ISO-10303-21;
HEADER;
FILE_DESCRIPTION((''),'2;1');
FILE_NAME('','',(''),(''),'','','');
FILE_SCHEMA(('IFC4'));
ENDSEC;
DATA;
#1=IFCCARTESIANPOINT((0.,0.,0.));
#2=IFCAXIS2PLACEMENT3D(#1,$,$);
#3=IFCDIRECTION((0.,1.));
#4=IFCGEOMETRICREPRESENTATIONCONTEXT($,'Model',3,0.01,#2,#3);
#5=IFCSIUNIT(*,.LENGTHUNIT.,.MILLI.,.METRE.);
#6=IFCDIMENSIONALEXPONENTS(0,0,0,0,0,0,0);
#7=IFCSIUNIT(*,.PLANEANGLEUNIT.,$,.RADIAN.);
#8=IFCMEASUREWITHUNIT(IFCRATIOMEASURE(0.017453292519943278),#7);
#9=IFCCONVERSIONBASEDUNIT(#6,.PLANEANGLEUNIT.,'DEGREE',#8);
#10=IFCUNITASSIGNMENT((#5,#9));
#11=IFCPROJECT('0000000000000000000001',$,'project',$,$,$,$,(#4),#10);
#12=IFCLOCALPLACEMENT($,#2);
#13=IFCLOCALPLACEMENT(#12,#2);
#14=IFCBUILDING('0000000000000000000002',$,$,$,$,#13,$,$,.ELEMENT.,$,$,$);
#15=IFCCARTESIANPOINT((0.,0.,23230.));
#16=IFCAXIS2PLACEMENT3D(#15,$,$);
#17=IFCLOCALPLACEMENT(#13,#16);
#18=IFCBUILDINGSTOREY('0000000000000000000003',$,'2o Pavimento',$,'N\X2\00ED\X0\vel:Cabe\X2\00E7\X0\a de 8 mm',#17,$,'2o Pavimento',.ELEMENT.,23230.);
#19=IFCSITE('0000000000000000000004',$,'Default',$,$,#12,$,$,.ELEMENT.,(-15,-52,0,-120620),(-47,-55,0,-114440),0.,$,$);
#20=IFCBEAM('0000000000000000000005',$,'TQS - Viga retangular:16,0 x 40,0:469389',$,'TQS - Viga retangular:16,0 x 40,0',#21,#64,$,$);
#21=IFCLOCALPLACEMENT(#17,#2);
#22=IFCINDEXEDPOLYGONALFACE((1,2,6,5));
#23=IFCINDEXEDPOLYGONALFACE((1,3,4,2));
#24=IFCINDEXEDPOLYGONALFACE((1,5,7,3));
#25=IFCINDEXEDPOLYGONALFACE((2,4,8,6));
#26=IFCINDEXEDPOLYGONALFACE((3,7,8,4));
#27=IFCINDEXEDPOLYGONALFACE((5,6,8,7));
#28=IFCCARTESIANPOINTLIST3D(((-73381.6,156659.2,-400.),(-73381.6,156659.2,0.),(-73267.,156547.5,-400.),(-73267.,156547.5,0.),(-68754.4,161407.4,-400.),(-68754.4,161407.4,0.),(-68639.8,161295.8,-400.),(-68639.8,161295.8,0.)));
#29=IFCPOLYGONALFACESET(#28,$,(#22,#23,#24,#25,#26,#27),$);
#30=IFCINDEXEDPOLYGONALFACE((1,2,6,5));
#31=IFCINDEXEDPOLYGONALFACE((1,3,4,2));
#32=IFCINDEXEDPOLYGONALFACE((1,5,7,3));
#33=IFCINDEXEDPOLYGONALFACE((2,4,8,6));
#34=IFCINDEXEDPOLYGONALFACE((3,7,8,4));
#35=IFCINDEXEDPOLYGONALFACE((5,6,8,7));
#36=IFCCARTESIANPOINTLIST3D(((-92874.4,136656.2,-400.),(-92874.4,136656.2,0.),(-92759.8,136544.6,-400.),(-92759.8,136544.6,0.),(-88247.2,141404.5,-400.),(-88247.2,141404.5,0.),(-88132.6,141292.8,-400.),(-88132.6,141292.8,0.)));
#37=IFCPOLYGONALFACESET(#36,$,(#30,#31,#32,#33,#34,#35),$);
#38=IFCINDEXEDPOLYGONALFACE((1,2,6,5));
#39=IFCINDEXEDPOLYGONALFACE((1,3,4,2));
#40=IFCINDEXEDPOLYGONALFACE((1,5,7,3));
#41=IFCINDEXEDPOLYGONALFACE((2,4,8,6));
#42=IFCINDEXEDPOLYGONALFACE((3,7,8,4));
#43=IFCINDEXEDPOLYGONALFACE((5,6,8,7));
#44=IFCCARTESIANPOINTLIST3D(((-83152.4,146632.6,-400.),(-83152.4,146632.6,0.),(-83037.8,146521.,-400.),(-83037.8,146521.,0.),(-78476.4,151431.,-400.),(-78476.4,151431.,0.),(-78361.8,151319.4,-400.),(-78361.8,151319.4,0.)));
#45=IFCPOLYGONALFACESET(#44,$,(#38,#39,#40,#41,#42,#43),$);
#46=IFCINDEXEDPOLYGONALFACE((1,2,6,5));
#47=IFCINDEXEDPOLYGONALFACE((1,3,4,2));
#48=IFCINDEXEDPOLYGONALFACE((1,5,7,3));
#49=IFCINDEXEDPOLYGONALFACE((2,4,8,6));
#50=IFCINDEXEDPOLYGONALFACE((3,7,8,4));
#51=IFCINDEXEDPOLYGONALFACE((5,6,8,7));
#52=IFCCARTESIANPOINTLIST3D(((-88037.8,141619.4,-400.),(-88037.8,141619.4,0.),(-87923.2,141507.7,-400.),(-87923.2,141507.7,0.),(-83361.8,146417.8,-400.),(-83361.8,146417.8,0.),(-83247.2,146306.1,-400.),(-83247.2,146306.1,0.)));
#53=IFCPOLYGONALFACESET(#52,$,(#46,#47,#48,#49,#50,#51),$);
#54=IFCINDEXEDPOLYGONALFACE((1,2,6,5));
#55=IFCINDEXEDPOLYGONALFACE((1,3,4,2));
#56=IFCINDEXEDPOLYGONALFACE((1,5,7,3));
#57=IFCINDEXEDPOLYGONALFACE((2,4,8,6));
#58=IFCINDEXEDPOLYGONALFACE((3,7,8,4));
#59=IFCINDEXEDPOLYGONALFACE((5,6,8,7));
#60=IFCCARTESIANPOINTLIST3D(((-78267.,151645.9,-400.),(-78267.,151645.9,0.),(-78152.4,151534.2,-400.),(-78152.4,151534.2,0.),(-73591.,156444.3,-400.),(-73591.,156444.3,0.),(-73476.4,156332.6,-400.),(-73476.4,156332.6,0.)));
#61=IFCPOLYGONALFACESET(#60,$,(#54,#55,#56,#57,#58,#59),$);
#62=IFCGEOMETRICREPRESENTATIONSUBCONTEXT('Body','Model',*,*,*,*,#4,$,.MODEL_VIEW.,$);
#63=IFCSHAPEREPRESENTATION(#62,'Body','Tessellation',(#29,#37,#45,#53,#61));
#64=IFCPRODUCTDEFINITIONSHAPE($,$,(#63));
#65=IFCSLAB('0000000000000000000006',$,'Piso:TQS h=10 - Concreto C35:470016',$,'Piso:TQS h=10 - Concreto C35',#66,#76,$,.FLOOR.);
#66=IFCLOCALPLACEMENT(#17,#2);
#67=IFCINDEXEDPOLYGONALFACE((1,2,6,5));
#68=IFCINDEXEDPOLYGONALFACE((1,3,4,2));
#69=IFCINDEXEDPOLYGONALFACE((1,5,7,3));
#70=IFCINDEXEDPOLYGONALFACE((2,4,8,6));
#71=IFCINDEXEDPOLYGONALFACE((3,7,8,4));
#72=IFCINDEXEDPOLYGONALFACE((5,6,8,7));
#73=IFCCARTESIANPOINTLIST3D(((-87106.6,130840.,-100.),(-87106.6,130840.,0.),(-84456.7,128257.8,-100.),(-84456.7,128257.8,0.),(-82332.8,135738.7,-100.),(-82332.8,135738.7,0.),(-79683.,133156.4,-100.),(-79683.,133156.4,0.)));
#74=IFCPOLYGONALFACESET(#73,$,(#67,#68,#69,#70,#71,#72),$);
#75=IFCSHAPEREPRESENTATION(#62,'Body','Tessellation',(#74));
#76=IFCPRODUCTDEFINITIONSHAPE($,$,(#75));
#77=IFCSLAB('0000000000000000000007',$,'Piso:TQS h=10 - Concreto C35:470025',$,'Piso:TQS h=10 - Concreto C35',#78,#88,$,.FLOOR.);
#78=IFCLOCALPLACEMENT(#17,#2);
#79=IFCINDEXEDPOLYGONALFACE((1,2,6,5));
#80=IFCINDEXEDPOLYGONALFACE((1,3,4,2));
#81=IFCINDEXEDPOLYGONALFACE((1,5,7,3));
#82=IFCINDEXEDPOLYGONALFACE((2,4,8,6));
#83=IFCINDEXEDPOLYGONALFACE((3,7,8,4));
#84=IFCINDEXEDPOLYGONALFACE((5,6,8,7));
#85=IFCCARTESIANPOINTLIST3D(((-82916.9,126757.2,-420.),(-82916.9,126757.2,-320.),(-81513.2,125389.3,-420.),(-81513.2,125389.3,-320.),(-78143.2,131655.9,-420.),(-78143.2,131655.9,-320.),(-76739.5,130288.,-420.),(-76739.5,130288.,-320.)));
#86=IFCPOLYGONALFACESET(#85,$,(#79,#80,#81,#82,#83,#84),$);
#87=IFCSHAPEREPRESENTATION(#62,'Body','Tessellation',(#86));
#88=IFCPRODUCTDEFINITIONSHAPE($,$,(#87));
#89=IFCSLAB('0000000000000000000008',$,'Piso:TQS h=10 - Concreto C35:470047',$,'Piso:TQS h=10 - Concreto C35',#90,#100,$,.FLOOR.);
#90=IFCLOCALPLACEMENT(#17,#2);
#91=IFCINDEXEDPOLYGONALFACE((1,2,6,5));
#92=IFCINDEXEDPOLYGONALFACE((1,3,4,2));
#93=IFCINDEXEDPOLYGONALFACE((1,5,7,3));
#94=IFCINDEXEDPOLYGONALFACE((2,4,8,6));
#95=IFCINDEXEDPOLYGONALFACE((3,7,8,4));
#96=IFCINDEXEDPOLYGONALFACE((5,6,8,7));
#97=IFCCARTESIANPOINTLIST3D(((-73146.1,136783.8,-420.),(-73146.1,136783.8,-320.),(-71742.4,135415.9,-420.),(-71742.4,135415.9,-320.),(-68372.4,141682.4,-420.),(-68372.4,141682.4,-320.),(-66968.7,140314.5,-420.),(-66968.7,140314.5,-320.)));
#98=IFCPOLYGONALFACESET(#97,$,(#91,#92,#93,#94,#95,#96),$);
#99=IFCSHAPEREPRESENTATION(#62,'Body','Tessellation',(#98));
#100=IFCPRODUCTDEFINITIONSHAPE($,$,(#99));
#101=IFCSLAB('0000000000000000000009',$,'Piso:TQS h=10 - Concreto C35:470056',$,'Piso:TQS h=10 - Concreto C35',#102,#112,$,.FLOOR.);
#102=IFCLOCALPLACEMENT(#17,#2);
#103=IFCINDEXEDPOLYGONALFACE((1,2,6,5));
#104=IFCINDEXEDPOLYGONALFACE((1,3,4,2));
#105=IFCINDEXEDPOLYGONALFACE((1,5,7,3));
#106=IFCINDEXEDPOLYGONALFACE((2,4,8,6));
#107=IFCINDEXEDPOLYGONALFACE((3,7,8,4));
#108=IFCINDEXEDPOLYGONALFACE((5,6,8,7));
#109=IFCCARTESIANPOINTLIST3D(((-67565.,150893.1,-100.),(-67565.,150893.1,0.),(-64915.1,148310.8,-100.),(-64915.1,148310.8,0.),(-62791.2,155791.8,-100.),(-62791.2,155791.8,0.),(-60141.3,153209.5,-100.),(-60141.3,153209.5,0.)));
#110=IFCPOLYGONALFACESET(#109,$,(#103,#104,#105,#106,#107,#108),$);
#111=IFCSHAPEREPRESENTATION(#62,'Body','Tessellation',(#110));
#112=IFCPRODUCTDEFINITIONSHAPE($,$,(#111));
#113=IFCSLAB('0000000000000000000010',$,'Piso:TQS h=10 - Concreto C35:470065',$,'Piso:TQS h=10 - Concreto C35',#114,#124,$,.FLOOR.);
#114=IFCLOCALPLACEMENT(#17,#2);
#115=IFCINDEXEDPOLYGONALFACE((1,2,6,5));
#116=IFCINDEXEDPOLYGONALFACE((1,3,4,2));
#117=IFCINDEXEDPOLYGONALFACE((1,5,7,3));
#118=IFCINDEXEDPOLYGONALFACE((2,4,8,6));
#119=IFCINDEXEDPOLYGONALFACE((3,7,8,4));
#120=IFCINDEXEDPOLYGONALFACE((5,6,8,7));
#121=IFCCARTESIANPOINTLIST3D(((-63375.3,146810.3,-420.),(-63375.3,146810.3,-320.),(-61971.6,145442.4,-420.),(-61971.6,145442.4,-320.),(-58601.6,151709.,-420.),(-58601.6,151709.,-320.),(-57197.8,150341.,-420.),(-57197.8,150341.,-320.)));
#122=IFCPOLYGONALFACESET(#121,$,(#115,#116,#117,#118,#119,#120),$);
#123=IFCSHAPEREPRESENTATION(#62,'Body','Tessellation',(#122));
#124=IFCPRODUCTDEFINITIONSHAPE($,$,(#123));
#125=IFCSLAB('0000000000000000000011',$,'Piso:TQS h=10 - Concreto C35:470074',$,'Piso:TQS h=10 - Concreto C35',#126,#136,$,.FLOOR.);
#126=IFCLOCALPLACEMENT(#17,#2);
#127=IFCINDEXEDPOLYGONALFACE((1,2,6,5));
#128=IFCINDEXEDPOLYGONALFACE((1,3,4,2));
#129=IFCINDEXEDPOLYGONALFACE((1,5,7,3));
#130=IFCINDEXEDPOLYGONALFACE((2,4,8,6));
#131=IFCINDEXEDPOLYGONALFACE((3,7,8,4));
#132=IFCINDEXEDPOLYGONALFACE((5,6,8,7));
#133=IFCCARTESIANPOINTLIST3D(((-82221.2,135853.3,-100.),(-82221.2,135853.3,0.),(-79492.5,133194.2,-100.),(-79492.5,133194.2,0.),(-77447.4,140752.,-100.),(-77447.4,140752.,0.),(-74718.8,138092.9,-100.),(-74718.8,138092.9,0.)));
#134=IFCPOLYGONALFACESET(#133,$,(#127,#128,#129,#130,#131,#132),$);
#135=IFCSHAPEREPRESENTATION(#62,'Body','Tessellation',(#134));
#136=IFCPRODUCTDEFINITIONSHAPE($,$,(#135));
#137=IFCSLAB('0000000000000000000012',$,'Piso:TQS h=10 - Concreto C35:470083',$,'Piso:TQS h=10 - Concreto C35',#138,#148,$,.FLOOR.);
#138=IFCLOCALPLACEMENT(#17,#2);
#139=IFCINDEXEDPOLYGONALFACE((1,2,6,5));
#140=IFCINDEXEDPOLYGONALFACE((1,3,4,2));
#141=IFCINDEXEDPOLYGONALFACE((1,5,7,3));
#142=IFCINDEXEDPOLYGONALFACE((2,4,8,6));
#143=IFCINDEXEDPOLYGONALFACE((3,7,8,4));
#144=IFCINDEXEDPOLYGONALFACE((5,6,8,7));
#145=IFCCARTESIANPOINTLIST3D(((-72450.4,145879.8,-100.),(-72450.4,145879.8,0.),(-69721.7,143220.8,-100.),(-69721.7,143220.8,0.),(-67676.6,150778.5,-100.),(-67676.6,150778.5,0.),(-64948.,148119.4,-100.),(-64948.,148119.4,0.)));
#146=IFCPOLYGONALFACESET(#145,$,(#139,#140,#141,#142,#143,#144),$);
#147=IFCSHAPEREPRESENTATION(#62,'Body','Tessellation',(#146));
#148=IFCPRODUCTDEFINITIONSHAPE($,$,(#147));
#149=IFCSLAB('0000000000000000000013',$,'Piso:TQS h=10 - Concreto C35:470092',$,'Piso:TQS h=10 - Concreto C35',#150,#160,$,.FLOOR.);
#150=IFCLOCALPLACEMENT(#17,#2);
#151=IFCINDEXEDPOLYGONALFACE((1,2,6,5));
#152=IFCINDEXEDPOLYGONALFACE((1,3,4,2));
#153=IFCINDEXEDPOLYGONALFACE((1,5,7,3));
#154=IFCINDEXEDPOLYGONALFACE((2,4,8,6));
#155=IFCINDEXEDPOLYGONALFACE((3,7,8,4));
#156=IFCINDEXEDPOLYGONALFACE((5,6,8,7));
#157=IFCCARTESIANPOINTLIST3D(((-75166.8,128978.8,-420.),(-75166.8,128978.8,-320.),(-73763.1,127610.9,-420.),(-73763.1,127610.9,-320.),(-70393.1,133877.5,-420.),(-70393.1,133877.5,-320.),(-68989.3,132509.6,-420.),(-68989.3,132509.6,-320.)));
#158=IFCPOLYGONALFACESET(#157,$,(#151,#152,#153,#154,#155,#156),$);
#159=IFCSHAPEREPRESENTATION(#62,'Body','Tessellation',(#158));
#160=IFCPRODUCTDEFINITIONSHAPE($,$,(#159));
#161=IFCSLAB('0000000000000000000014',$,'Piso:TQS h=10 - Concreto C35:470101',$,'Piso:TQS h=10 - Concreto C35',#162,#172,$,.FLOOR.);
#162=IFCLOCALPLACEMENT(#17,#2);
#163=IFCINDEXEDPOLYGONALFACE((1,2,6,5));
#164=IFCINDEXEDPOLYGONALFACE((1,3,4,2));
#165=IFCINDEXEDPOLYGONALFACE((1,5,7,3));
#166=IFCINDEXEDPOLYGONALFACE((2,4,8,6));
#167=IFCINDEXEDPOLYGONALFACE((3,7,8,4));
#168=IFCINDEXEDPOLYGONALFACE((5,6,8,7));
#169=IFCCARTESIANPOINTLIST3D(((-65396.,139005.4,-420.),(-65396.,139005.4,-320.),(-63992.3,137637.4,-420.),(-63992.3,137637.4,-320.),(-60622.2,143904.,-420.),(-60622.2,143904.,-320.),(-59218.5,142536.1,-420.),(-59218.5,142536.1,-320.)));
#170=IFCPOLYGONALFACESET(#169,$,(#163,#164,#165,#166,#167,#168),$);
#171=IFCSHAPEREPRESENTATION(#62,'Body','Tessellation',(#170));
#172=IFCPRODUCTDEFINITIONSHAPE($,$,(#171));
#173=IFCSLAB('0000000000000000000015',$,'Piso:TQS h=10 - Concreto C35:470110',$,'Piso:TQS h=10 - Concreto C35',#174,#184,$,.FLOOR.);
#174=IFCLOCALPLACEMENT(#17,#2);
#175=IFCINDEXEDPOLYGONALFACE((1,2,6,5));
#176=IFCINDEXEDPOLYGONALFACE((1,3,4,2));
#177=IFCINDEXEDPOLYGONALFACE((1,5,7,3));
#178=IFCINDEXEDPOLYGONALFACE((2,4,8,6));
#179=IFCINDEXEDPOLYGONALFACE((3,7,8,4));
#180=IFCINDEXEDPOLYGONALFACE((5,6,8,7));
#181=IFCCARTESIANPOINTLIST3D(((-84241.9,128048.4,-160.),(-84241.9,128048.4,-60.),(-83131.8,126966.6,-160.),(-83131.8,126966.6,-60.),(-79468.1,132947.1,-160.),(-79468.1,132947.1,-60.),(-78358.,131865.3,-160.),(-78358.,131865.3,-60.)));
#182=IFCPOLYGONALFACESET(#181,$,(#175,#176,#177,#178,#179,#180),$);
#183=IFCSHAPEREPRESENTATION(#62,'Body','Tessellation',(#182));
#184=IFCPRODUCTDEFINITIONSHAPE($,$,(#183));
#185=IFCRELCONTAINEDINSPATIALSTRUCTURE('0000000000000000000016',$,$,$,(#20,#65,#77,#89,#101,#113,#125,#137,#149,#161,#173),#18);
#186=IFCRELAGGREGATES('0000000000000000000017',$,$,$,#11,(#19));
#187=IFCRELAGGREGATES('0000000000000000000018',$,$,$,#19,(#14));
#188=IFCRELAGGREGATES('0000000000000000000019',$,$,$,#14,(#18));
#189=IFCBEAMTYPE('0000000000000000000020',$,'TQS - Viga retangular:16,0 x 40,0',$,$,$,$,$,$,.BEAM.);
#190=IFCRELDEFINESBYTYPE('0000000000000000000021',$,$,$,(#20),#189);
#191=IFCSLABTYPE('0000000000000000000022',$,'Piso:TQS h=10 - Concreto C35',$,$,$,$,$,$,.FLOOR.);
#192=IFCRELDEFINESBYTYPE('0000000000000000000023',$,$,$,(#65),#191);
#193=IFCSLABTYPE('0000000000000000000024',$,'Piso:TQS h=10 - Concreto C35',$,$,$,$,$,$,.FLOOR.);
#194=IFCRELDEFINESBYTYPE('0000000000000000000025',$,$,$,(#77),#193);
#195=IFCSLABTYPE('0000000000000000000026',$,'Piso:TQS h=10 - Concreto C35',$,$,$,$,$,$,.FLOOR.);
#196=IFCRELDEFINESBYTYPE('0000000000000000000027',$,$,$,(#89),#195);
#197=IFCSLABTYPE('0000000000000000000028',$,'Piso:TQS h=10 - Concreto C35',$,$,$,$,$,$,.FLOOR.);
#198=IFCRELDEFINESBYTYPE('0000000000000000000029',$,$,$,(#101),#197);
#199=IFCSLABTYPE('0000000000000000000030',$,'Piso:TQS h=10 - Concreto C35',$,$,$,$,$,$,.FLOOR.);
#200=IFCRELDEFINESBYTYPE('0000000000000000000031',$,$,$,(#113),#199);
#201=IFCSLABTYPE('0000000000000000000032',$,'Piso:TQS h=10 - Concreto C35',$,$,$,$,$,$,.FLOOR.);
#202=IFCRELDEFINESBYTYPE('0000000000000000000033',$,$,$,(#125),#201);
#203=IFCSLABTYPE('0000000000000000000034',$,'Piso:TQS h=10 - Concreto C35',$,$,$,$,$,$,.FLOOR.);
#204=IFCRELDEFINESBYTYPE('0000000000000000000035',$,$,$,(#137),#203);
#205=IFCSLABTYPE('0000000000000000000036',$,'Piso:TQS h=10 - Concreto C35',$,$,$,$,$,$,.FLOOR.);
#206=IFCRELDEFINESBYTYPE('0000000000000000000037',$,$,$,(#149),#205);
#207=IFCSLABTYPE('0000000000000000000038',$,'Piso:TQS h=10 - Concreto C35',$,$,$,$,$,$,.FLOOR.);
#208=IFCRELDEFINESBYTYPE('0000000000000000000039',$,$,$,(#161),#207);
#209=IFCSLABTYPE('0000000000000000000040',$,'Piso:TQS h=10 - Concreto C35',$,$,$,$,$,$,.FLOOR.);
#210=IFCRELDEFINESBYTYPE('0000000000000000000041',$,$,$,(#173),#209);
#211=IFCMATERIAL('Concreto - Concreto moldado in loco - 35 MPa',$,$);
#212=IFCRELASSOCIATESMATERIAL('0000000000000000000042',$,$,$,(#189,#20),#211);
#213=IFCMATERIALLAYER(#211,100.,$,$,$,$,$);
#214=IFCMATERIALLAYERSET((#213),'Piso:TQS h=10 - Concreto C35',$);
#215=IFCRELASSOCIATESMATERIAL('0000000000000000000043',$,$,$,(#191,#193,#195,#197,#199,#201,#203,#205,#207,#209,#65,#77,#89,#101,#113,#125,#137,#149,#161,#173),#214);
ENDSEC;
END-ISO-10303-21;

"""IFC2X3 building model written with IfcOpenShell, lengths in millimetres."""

from ifc_helpers import new_model, entity, si_unit, converted_unit, direction, frame, frame_2d, origin, place, context, subcontext, project, spatial, rectangle, extrude, source, transform, mapped, material, layer, layer_set, layer_usage, type_object, type_shapes, element, save


model = new_model("IFC2X3")

# Units and contexts
model_context = context("Model", 3, precision=0.01, world=origin(), true_north=direction((0.0, 1.0)))
body_context = subcontext(model_context, "Body", "Model", "MODEL_VIEW")
ifc_project = project(units=[si_unit("LENGTHUNIT", "METRE", prefix="MILLI"), converted_unit("PLANEANGLEUNIT", "DEGREE", entity("IfcRatioMeasure", 0.017453292519943278), si_unit("PLANEANGLEUNIT", "RADIAN"), dimensions=[0, 0, 0, 0, 0, 0, 0])], contexts=[model_context])

# Site, building, storey
site_placement = place(None, origin())
site = spatial("IfcSite", under=ifc_project, at=site_placement, Name="Default", CompositionType="ELEMENT", RefLatitude=(-15, -52, 0, -120620), RefLongitude=(-47, -55, 0, -114440), RefElevation=0.0)
building_placement = place(site_placement, origin())
building = spatial("IfcBuilding", under=site, at=building_placement, CompositionType="ELEMENT")
storey_placement = place(building_placement, frame((0.0, 0.0, 23230.0)))
storey = spatial("IfcBuildingStorey", under=building, at=storey_placement, Name="2o Pavimento", ObjectType="Nível:Cabeça de 8 mm", LongName="2o Pavimento", CompositionType="ELEMENT", Elevation=23230.0)

# Beam
ifc_material = material(Name="Concreto - Concreto moldado in loco - 35 MPa")
beam_type_1 = type_object("IfcBeamType", Name="TQS - Viga retangular:16,0 x 40,0", PredefinedType="BEAM", material=ifc_material)
shared_shape_1 = source(origin(), body_context, "Body", "SweptSolid", [
    extrude(rectangle(XDim=400.0, YDim=160.0, at=frame_2d((0.0, 0.0), x_axis=(1.0, 0.0))), frame((-73324.3, 156603.3, 23030.0), z_axis=(0.697915, 0.71618, 0.0), x_axis=(0.0, 0.0, 1.0)), (0.0, 0.0, 1.0), 6630.0),
    extrude(rectangle(XDim=400.0, YDim=160.0, at=frame_2d((0.0, 0.0), x_axis=(1.0, 0.0))), frame((-92817.1, 136600.4, 23030.0), z_axis=(0.697915, 0.71618, 0.0), x_axis=(0.0, 0.0, 1.0)), (0.0, 0.0, 1.0), 6630.0),
    extrude(rectangle(XDim=400.0, YDim=160.0, at=frame_2d((0.0, 0.0), x_axis=(1.0, 0.0))), frame((-83095.1, 146576.8, 23030.0), z_axis=(0.697915, 0.71618, 0.0), x_axis=(0.0, 0.0, 1.0)), (0.0, 0.0, 1.0), 6700.0),
    extrude(rectangle(XDim=400.0, YDim=160.0, at=frame_2d((0.0, 0.0), x_axis=(1.0, 0.0))), frame((-87980.5, 141563.5, 23030.0), z_axis=(0.697915, 0.71618, 0.0), x_axis=(0.0, 0.0, 1.0)), (0.0, 0.0, 1.0), 6700.0),
    extrude(rectangle(XDim=400.0, YDim=160.0, at=frame_2d((0.0, 0.0), x_axis=(1.0, 0.0))), frame((-78209.7, 151590.1, 23030.0), z_axis=(0.697915, 0.71618, 0.0), x_axis=(0.0, 0.0, 1.0)), (0.0, 0.0, 1.0), 6700.0),
])
type_shapes(beam_type_1, [shared_shape_1])
beam_1_placement = place(storey_placement, frame((0.0, 0.0, -23230.0)))
element("IfcBeam", 1, at=beam_1_placement, inside=storey, type_object=beam_type_1, material=ifc_material, Name="TQS - Viga retangular:16,0 x 40,0:469389", ObjectType="TQS - Viga retangular:16,0 x 40,0", context=body_context, shape_type="MappedRepresentation", body=[
    mapped(shared_shape_1, transform((0.0, 0.0, 0.0), scale=1.0)),
])

# Slabs
ifc_layer = layer(ifc_material, 100.0)
ifc_layer_set = layer_set([ifc_layer], Name="Piso:TQS h=10 - Concreto C35")
ifc_layer_usage_1 = layer_usage(ifc_layer_set, "AXIS3", "POSITIVE", 0.0)
slab_type_1 = type_object("IfcSlabType", Name="Piso:TQS h=10 - Concreto C35", PredefinedType="FLOOR", material=ifc_layer_set)
slab_1_placement = place(storey_placement, origin())
element("IfcSlab", 2, at=slab_1_placement, inside=storey, type_object=slab_type_1, material=ifc_layer_usage_1, Name="Piso:TQS h=10 - Concreto C35:470016", ObjectType="Piso:TQS h=10 - Concreto C35", PredefinedType="FLOOR", context=body_context, shape_type="SweptSolid", body=[
    extrude(rectangle(XDim=6840.0, YDim=3700.0, at=frame_2d((0.0, 0.0), x_axis=(1.0, 0.0))), frame((-83394.8, 131998.2, 0.0), z_axis=(0.0, 0.0, -1.0), x_axis=(-0.697915, -0.71618, 0.0)), (0.0, 0.0, 1.0), 100.0),
])
ifc_layer_usage_2 = layer_usage(ifc_layer_set, "AXIS3", "POSITIVE", 0.0)
slab_type_2 = type_object("IfcSlabType", Name="Piso:TQS h=10 - Concreto C35", PredefinedType="FLOOR", material=ifc_layer_set)
slab_2_placement = place(storey_placement, origin())
element("IfcSlab", 3, at=slab_2_placement, inside=storey, type_object=slab_type_2, material=ifc_layer_usage_2, Name="Piso:TQS h=10 - Concreto C35:470025", ObjectType="Piso:TQS h=10 - Concreto C35", PredefinedType="FLOOR", context=body_context, shape_type="SweptSolid", body=[
    extrude(rectangle(XDim=1960.0, YDim=6840.0, at=frame_2d((0.0, 0.0), x_axis=(1.0, 0.0))), frame((-79828.2, 128522.6, -320.0), z_axis=(0.0, 0.0, -1.0), x_axis=(0.71618, -0.697915, 0.0)), (0.0, 0.0, 1.0), 100.0),
])
ifc_layer_usage_3 = layer_usage(ifc_layer_set, "AXIS3", "POSITIVE", 0.0)
slab_type_3 = type_object("IfcSlabType", Name="Piso:TQS h=10 - Concreto C35", PredefinedType="FLOOR", material=ifc_layer_set)
slab_3_placement = place(storey_placement, origin())
element("IfcSlab", 4, at=slab_3_placement, inside=storey, type_object=slab_type_3, material=ifc_layer_usage_3, Name="Piso:TQS h=10 - Concreto C35:470047", ObjectType="Piso:TQS h=10 - Concreto C35", PredefinedType="FLOOR", context=body_context, shape_type="SweptSolid", body=[
    extrude(rectangle(XDim=6840.0, YDim=1960.0, at=frame_2d((0.0, 0.0), x_axis=(1.0, 0.0))), frame((-70057.4, 138549.1, -320.0), z_axis=(0.0, 0.0, -1.0), x_axis=(-0.697915, -0.71618, 0.0)), (0.0, 0.0, 1.0), 100.0),
])
ifc_layer_usage_4 = layer_usage(ifc_layer_set, "AXIS3", "POSITIVE", 0.0)
slab_type_4 = type_object("IfcSlabType", Name="Piso:TQS h=10 - Concreto C35", PredefinedType="FLOOR", material=ifc_layer_set)
slab_4_placement = place(storey_placement, origin())
element("IfcSlab", 5, at=slab_4_placement, inside=storey, type_object=slab_type_4, material=ifc_layer_usage_4, Name="Piso:TQS h=10 - Concreto C35:470056", ObjectType="Piso:TQS h=10 - Concreto C35", PredefinedType="FLOOR", context=body_context, shape_type="SweptSolid", body=[
    extrude(rectangle(XDim=3700.0, YDim=6840.0, at=frame_2d((0.0, 0.0), x_axis=(1.0, 0.0))), frame((-63853.1, 152051.3, 0.0), z_axis=(0.0, 0.0, -1.0), x_axis=(0.71618, -0.697915, 0.0)), (0.0, 0.0, 1.0), 100.0),
])
ifc_layer_usage_5 = layer_usage(ifc_layer_set, "AXIS3", "POSITIVE", 0.0)
slab_type_5 = type_object("IfcSlabType", Name="Piso:TQS h=10 - Concreto C35", PredefinedType="FLOOR", material=ifc_layer_set)
slab_5_placement = place(storey_placement, origin())
element("IfcSlab", 6, at=slab_5_placement, inside=storey, type_object=slab_type_5, material=ifc_layer_usage_5, Name="Piso:TQS h=10 - Concreto C35:470065", ObjectType="Piso:TQS h=10 - Concreto C35", PredefinedType="FLOOR", context=body_context, shape_type="SweptSolid", body=[
    extrude(rectangle(XDim=6840.0, YDim=1960.0, at=frame_2d((0.0, 0.0), x_axis=(1.0, 0.0))), frame((-60286.6, 148575.7, -320.0), z_axis=(0.0, 0.0, -1.0), x_axis=(-0.697915, -0.71618, 0.0)), (0.0, 0.0, 1.0), 100.0),
])
ifc_layer_usage_6 = layer_usage(ifc_layer_set, "AXIS3", "POSITIVE", 0.0)
slab_type_6 = type_object("IfcSlabType", Name="Piso:TQS h=10 - Concreto C35", PredefinedType="FLOOR", material=ifc_layer_set)
slab_6_placement = place(storey_placement, origin())
element("IfcSlab", 7, at=slab_6_placement, inside=storey, type_object=slab_type_6, material=ifc_layer_usage_6, Name="Piso:TQS h=10 - Concreto C35:470074", ObjectType="Piso:TQS h=10 - Concreto C35", PredefinedType="FLOOR", context=body_context, shape_type="SweptSolid", body=[
    extrude(rectangle(XDim=6840.0, YDim=3810.0, at=frame_2d((0.0, 0.0), x_axis=(1.0, 0.0))), frame((-78470.0, 136973.1, 0.0), z_axis=(0.0, 0.0, -1.0), x_axis=(-0.697915, -0.71618, 0.0)), (0.0, 0.0, 1.0), 100.0),
])
ifc_layer_usage_7 = layer_usage(ifc_layer_set, "AXIS3", "POSITIVE", 0.0)
slab_type_7 = type_object("IfcSlabType", Name="Piso:TQS h=10 - Concreto C35", PredefinedType="FLOOR", material=ifc_layer_set)
slab_7_placement = place(storey_placement, origin())
element("IfcSlab", 8, at=slab_7_placement, inside=storey, type_object=slab_type_7, material=ifc_layer_usage_7, Name="Piso:TQS h=10 - Concreto C35:470083", ObjectType="Piso:TQS h=10 - Concreto C35", PredefinedType="FLOOR", context=body_context, shape_type="SweptSolid", body=[
    extrude(rectangle(XDim=3810.0, YDim=6840.0, at=frame_2d((0.0, 0.0), x_axis=(1.0, 0.0))), frame((-68699.2, 146999.6, 0.0), z_axis=(0.0, 0.0, -1.0), x_axis=(0.71618, -0.697915, 0.0)), (0.0, 0.0, 1.0), 100.0),
])
ifc_layer_usage_8 = layer_usage(ifc_layer_set, "AXIS3", "POSITIVE", 0.0)
slab_type_8 = type_object("IfcSlabType", Name="Piso:TQS h=10 - Concreto C35", PredefinedType="FLOOR", material=ifc_layer_set)
slab_8_placement = place(storey_placement, origin())
element("IfcSlab", 9, at=slab_8_placement, inside=storey, type_object=slab_type_8, material=ifc_layer_usage_8, Name="Piso:TQS h=10 - Concreto C35:470092", ObjectType="Piso:TQS h=10 - Concreto C35", PredefinedType="FLOOR", context=body_context, shape_type="SweptSolid", body=[
    extrude(rectangle(XDim=6840.0, YDim=1960.0, at=frame_2d((0.0, 0.0), x_axis=(1.0, 0.0))), frame((-72078.1, 130744.2, -320.0), z_axis=(0.0, 0.0, -1.0), x_axis=(-0.697915, -0.71618, 0.0)), (0.0, 0.0, 1.0), 100.0),
])
ifc_layer_usage_9 = layer_usage(ifc_layer_set, "AXIS3", "POSITIVE", 0.0)
slab_type_9 = type_object("IfcSlabType", Name="Piso:TQS h=10 - Concreto C35", PredefinedType="FLOOR", material=ifc_layer_set)
slab_9_placement = place(storey_placement, origin())
element("IfcSlab", 10, at=slab_9_placement, inside=storey, type_object=slab_type_9, material=ifc_layer_usage_9, Name="Piso:TQS h=10 - Concreto C35:470101", ObjectType="Piso:TQS h=10 - Concreto C35", PredefinedType="FLOOR", context=body_context, shape_type="SweptSolid", body=[
    extrude(rectangle(XDim=1960.0, YDim=6840.0, at=frame_2d((0.0, 0.0), x_axis=(1.0, 0.0))), frame((-62307.3, 140770.7, -320.0), z_axis=(0.0, 0.0, -1.0), x_axis=(0.71618, -0.697915, 0.0)), (0.0, 0.0, 1.0), 100.0),
])
ifc_layer_usage_10 = layer_usage(ifc_layer_set, "AXIS3", "POSITIVE", 0.0)
slab_type_10 = type_object("IfcSlabType", Name="Piso:TQS h=10 - Concreto C35", PredefinedType="FLOOR", material=ifc_layer_set)
slab_10_placement = place(storey_placement, origin())
element("IfcSlab", 11, at=slab_10_placement, inside=storey, type_object=slab_type_10, material=ifc_layer_usage_10, Name="Piso:TQS h=10 - Concreto C35:470110", ObjectType="Piso:TQS h=10 - Concreto C35", PredefinedType="FLOOR", context=body_context, shape_type="SweptSolid", body=[
    extrude(rectangle(XDim=6840.0, YDim=1550.0, at=frame_2d((0.0, 0.0), x_axis=(1.0, 0.0))), frame((-81300.0, 129956.8, -60.0), z_axis=(0.0, 0.0, -1.0), x_axis=(-0.697915, -0.71618, 0.0)), (0.0, 0.0, 1.0), 100.0),
])

save(model, "model.ifc")
